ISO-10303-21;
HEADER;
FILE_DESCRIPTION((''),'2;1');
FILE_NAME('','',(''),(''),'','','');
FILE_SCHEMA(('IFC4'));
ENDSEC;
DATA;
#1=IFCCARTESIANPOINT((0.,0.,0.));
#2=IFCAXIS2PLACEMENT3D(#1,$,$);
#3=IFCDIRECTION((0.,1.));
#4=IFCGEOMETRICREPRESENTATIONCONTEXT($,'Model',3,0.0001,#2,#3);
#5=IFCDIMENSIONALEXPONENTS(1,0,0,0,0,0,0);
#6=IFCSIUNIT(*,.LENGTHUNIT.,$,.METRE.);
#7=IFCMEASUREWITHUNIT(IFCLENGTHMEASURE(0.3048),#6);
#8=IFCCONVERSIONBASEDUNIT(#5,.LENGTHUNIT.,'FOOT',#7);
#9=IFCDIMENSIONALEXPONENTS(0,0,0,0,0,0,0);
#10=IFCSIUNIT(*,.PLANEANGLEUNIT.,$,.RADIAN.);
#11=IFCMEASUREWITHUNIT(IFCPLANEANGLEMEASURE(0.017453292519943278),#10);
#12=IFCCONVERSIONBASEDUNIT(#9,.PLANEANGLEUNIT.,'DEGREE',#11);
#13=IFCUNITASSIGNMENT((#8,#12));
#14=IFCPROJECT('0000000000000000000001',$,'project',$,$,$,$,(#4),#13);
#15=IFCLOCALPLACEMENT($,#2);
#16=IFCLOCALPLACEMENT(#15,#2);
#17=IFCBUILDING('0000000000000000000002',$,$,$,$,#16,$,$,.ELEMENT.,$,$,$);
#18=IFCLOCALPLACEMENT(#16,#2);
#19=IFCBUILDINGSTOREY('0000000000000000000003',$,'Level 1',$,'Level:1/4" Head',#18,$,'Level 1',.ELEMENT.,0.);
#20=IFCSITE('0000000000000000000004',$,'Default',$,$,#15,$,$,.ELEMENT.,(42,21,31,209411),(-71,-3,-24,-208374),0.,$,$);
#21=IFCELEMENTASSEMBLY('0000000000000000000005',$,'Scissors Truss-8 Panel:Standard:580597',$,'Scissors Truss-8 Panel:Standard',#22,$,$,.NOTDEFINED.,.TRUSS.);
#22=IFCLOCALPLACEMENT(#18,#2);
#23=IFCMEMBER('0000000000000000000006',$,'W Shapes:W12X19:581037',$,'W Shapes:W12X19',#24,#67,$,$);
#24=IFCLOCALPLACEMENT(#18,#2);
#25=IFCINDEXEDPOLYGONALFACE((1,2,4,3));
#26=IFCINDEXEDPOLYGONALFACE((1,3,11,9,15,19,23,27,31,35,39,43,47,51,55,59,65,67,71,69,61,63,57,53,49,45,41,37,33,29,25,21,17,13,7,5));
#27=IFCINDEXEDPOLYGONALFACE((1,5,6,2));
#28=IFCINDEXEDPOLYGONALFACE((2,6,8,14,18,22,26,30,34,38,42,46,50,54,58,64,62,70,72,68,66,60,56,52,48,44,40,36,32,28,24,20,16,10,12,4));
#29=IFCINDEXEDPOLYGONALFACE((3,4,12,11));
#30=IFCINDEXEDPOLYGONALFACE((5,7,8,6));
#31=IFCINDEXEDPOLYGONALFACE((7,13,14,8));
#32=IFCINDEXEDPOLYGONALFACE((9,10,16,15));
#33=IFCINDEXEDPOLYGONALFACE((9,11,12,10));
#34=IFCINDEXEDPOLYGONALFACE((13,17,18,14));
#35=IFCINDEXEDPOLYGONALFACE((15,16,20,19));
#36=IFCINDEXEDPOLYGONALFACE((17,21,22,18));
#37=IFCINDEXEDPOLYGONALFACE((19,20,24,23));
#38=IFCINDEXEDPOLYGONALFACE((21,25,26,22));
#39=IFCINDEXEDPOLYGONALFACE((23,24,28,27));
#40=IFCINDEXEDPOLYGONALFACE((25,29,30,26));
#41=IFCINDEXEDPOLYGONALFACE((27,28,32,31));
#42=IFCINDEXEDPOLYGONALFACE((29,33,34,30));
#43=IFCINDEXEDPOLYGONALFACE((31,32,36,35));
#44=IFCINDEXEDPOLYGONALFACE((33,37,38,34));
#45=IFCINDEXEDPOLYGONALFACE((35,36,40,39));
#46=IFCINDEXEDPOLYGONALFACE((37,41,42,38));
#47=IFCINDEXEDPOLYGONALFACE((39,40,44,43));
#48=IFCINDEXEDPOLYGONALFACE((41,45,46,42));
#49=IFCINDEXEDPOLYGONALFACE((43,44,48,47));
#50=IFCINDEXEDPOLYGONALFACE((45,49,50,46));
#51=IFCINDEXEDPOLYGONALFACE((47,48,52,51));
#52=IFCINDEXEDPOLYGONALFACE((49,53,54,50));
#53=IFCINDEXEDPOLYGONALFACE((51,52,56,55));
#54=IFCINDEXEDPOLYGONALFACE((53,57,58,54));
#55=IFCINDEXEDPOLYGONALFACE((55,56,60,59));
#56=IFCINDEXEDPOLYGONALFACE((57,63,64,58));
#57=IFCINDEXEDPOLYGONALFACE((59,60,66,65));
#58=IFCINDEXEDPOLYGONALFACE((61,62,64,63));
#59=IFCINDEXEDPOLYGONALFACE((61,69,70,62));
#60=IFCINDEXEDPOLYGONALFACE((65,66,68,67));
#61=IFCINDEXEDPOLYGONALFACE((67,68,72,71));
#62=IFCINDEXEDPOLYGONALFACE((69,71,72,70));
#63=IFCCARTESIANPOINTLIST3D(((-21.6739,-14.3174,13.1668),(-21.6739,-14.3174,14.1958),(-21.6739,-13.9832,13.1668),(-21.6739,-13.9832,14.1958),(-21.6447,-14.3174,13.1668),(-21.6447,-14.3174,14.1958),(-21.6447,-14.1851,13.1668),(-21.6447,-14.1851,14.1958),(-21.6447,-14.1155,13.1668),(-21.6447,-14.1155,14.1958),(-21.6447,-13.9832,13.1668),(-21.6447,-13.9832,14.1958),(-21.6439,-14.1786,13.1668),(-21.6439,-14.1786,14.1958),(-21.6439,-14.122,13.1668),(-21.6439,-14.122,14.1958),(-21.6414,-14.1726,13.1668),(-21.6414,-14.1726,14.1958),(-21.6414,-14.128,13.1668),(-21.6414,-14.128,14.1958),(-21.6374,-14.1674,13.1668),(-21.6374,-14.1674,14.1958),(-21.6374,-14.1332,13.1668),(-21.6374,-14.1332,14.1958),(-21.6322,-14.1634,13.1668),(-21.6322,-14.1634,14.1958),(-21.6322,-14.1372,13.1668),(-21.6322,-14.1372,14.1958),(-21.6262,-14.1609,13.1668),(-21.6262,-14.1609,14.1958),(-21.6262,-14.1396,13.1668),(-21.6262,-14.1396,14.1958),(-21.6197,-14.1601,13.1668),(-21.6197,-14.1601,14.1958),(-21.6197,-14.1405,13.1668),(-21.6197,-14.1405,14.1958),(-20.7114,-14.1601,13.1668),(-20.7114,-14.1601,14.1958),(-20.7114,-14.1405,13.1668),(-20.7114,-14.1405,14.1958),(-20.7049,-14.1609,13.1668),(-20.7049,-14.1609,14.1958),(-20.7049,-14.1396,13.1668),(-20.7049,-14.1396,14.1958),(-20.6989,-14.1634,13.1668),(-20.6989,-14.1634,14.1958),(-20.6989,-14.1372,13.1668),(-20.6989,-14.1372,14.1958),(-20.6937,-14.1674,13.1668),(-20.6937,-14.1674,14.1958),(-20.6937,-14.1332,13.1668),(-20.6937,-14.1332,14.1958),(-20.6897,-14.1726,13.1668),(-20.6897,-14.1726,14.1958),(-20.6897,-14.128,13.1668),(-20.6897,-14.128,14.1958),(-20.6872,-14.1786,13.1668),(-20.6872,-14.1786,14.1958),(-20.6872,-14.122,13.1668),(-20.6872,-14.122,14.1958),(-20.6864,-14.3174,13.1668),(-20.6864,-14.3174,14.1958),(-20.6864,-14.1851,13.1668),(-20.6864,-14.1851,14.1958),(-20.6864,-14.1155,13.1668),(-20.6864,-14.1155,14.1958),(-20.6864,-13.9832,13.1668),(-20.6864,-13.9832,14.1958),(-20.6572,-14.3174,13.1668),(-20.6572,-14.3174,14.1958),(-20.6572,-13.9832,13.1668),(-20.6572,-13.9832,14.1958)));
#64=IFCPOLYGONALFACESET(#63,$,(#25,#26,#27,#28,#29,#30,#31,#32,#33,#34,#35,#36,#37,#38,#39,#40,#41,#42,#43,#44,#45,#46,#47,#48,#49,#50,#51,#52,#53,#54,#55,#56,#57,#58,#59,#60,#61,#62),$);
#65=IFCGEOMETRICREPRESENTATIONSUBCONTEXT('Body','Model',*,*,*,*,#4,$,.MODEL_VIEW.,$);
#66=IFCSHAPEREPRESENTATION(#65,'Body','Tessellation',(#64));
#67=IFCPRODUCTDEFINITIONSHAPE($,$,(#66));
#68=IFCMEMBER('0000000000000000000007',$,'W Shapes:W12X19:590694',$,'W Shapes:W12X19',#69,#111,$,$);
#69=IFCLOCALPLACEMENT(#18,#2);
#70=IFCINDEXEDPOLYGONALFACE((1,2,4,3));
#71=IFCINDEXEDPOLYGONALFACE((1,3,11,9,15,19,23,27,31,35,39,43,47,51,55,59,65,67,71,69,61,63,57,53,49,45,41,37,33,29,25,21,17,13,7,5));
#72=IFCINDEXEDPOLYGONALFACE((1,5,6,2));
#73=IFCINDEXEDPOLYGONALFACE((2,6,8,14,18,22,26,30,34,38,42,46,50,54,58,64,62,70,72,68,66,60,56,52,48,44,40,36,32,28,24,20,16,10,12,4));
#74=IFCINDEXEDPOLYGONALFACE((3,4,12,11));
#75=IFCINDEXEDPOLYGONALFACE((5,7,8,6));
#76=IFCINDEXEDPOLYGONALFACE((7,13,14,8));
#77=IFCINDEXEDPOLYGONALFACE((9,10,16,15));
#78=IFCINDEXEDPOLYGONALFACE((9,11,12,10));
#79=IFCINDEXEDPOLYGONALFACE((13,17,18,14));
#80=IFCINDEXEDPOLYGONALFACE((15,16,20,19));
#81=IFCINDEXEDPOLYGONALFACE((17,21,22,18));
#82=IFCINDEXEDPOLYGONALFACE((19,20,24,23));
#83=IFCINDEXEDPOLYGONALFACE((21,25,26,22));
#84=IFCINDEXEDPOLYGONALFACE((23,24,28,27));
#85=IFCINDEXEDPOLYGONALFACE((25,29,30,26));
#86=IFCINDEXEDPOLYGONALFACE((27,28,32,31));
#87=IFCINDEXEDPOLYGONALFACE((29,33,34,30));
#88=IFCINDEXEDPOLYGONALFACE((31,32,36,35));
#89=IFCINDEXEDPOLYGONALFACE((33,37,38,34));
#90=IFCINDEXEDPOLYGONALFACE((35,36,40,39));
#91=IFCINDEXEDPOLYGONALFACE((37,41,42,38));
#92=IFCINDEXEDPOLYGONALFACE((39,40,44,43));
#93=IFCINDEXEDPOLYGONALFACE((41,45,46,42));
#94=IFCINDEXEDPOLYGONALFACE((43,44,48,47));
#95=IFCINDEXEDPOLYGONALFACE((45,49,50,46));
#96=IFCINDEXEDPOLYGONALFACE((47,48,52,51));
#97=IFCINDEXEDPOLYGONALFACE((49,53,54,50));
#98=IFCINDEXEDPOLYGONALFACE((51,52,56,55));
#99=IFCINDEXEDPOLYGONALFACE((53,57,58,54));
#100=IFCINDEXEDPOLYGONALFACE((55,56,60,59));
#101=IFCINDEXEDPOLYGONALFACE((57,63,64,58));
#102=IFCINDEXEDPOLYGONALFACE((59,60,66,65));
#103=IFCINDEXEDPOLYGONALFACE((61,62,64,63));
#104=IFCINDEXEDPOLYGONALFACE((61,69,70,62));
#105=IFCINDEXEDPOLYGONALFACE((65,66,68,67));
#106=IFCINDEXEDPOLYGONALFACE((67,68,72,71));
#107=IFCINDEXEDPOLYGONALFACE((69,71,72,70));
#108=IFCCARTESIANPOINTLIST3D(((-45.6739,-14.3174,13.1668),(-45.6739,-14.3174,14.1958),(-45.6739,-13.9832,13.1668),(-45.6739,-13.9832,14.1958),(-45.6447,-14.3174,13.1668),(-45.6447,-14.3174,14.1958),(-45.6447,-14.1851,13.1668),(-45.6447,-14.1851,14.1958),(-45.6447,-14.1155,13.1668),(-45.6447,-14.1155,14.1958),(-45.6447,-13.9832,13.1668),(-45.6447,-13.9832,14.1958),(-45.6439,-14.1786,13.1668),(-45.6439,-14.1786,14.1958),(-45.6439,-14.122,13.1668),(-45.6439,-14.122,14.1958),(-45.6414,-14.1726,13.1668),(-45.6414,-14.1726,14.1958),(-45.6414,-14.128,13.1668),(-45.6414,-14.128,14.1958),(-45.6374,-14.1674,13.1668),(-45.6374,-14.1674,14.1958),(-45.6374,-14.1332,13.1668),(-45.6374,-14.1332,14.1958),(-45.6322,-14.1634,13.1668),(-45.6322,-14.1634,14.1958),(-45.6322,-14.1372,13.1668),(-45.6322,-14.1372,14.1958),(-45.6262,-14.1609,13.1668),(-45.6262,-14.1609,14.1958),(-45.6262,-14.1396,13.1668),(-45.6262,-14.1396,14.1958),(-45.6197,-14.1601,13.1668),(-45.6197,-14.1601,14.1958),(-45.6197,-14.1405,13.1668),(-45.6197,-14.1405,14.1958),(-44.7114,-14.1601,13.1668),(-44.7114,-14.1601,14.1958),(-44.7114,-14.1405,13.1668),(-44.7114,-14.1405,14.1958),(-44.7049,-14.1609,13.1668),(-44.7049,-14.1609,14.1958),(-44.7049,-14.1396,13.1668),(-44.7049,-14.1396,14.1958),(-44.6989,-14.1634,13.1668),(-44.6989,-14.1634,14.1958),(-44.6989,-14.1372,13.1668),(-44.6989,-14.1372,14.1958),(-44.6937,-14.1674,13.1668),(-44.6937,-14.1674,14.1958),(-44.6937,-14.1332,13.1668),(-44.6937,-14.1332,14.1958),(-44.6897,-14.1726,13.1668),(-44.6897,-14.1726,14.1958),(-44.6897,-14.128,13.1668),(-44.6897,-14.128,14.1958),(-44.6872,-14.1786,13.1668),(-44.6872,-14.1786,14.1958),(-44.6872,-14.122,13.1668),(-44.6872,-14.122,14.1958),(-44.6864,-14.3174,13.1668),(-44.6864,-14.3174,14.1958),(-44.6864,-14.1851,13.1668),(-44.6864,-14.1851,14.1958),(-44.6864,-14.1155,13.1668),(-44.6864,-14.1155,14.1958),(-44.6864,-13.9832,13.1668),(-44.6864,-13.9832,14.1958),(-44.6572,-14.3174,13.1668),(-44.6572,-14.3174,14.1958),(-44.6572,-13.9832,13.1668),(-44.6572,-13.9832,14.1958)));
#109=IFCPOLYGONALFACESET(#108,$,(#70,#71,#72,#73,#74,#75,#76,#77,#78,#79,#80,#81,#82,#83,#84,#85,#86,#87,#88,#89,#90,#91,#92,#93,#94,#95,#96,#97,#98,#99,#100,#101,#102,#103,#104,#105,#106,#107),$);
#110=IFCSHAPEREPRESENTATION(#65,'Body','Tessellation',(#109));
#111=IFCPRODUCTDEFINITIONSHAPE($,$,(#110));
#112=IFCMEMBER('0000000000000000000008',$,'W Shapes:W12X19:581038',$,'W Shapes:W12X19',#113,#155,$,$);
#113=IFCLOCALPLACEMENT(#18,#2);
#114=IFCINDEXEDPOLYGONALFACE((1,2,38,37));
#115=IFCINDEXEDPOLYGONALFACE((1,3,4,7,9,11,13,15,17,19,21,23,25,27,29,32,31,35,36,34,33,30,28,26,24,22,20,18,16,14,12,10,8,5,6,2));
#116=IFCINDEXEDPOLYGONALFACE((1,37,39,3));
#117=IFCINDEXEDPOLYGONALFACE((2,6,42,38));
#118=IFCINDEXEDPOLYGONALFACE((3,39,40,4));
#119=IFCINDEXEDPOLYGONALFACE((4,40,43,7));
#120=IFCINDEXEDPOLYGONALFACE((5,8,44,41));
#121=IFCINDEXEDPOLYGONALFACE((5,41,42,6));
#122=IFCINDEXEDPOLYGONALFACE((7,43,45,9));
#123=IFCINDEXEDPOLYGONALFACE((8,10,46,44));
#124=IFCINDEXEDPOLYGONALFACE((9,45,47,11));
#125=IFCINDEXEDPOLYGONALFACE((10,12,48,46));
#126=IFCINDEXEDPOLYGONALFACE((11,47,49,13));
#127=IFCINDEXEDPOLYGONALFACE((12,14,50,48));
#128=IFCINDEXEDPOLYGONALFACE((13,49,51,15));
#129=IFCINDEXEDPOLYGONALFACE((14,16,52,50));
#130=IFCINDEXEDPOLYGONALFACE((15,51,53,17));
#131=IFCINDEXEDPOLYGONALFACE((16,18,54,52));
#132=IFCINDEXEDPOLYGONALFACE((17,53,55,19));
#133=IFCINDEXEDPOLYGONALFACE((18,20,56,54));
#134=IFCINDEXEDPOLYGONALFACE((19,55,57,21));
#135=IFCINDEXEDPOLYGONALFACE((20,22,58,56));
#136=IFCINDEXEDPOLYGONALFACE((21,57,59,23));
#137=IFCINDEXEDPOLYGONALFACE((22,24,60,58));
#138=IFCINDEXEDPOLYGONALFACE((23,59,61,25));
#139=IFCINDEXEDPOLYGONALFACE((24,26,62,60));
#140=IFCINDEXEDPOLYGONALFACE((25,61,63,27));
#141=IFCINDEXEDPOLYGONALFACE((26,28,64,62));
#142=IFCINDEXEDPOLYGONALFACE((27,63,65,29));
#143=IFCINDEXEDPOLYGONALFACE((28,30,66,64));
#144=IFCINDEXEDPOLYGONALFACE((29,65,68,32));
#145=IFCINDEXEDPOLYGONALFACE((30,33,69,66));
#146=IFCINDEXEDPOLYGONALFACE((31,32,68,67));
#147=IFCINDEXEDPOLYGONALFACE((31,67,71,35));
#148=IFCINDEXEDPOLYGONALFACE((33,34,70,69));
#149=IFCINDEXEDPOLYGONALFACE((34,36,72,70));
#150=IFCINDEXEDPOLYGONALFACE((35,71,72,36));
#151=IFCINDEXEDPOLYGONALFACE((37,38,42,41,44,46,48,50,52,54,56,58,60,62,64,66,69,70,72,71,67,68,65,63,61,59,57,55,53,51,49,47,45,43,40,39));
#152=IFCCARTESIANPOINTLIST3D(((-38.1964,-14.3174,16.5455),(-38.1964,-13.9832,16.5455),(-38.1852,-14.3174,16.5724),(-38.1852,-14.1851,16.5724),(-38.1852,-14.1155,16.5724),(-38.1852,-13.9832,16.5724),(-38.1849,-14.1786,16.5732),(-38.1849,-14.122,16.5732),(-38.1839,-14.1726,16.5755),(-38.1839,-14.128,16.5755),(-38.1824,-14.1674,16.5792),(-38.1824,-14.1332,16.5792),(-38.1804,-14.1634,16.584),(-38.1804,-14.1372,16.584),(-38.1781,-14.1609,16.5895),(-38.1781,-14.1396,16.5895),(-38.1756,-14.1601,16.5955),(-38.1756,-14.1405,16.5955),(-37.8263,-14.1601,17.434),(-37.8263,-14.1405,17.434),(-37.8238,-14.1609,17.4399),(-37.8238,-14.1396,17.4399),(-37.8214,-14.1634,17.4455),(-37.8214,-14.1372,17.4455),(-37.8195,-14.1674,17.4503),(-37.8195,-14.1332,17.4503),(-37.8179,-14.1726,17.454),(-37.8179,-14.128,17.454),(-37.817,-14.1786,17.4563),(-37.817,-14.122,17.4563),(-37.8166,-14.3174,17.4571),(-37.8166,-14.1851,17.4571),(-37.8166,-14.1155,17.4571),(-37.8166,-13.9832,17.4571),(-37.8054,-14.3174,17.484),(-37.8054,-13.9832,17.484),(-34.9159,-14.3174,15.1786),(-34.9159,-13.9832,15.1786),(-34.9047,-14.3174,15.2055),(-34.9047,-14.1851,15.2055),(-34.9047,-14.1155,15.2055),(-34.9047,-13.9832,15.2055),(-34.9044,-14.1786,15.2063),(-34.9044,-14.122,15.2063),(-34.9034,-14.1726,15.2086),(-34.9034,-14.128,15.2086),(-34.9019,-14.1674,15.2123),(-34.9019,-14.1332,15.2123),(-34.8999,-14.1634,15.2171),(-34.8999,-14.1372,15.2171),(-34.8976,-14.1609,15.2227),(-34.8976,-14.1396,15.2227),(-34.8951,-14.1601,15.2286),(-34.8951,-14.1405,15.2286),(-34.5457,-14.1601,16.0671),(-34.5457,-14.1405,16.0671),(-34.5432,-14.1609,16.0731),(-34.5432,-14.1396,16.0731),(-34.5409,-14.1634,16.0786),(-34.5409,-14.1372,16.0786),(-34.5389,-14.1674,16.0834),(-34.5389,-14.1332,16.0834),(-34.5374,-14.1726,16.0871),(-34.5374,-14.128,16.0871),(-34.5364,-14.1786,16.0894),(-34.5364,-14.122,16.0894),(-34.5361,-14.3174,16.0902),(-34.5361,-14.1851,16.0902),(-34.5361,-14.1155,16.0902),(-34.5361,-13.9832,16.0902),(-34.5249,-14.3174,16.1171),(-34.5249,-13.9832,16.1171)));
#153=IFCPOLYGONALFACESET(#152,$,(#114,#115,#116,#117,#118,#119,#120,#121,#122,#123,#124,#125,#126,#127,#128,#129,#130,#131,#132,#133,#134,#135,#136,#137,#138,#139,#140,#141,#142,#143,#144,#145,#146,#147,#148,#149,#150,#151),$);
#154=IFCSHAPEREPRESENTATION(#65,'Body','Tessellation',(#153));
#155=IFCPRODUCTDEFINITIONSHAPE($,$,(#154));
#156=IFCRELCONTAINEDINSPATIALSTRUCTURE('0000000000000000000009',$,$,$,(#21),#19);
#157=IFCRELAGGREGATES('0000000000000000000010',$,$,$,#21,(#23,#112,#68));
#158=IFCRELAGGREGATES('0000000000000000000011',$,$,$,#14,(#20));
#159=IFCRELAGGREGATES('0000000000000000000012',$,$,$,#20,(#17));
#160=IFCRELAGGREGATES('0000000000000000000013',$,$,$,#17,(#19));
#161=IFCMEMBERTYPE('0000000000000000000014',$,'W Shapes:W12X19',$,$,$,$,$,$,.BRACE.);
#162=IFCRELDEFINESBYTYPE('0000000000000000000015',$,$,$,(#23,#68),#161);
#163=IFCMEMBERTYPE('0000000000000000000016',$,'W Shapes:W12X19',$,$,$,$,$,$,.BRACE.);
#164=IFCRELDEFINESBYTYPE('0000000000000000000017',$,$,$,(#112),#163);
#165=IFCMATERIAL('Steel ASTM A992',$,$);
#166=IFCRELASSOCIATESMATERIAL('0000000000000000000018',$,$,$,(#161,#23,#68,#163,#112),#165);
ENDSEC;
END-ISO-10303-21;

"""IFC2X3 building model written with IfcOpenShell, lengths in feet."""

from ifc_helpers import new_model, entity, si_unit, converted_unit, direction, frame, frame_2d, origin, place, context, subcontext, project, spatial, polyline, circle_curve, parameter, trimmed, segment, composite_curve, outline, extrude, source, transform, mapped, material, type_object, type_shapes, element, aggregate, save


model = new_model("IFC2X3")

# Units and contexts
model_context = context("Model", 3, precision=0.0001, world=origin(), true_north=direction((0.0, 1.0)))
body_context = subcontext(model_context, "Body", "Model", "MODEL_VIEW")
ifc_project = project(units=[converted_unit("LENGTHUNIT", "FOOT", entity("IfcLengthMeasure", 0.3048), si_unit("LENGTHUNIT", "METRE"), dimensions=[1, 0, 0, 0, 0, 0, 0]), converted_unit("PLANEANGLEUNIT", "DEGREE", entity("IfcPlaneAngleMeasure", 0.017453292519943278), si_unit("PLANEANGLEUNIT", "RADIAN"), dimensions=[0, 0, 0, 0, 0, 0, 0])], contexts=[model_context])

# Site, building, storey
site_placement = place(None, origin())
site = spatial("IfcSite", under=ifc_project, at=site_placement, Name="Default", CompositionType="ELEMENT", RefLatitude=(42, 21, 31, 209411), RefLongitude=(-71, -3, -24, -208374), RefElevation=0.0)
building_placement = place(site_placement, origin())
building = spatial("IfcBuilding", under=site, at=building_placement, CompositionType="ELEMENT")
storey_placement = place(building_placement, origin())
storey = spatial("IfcBuildingStorey", under=building, at=storey_placement, Name="Level 1", ObjectType="Level:1/4\" Head", LongName="Level 1", CompositionType="ELEMENT", Elevation=0.0)

# Element assembly, members
assembly_placement = place(storey_placement, origin())
assembly = element("IfcElementAssembly", 1, at=assembly_placement, inside=storey, Name="Scissors Truss-8 Panel:Standard:580597", ObjectType="Scissors Truss-8 Panel:Standard", AssemblyPlace="NOTDEFINED", PredefinedType="TRUSS")
ifc_material = material(Name="Steel ASTM A992")
member_type_1 = type_object("IfcMemberType", Name="W Shapes:W12X19", PredefinedType="BRACE", material=ifc_material)
shared_shape_1 = source(origin(), body_context, "Body", "SweptSolid", [
    extrude(outline(composite_curve([segment(polyline([(-0.1671, -0.4792), (-0.1671, -0.5083)]), True, "CONTINUOUS"), segment(polyline([(-0.1671, -0.5083), (0.1671, -0.5083)]), True, "CONTINUOUS"), segment(polyline([(0.1671, -0.5083), (0.1671, -0.4792)]), True, "CONTINUOUS"), segment(polyline([(0.1671, -0.4792), (0.0348, -0.4792)]), True, "CONTINUOUS"), segment(trimmed(circle_curve(frame_2d((0.0348, -0.4542), x_axis=(0.0, -1.0)), 0.025), [parameter(270.0)], [parameter(360.0)], True, "PARAMETER"), False, "CONTINUOUS"), segment(polyline([(0.0098, -0.4542), (0.0098, 0.4542)]), True, "CONTINUOUS"), segment(trimmed(circle_curve(frame_2d((0.0348, 0.4542), x_axis=(-1.0, 0.0)), 0.025), [parameter(270.0)], [parameter(360.0)], True, "PARAMETER"), False, "CONTINUOUS"), segment(polyline([(0.0348, 0.4792), (0.1671, 0.4792)]), True, "CONTINUOUS"), segment(polyline([(0.1671, 0.4792), (0.1671, 0.5083)]), True, "CONTINUOUS"), segment(polyline([(0.1671, 0.5083), (-0.1671, 0.5083)]), True, "CONTINUOUS"), segment(polyline([(-0.1671, 0.5083), (-0.1671, 0.4792)]), True, "CONTINUOUS"), segment(polyline([(-0.1671, 0.4792), (-0.0348, 0.4792)]), True, "CONTINUOUS"), segment(trimmed(circle_curve(frame_2d((-0.0348, 0.4542), x_axis=(0.0, 1.0)), 0.025), [parameter(270.0)], [parameter(0.0)], True, "PARAMETER"), False, "CONTINUOUS"), segment(polyline([(-0.0098, 0.4542), (-0.0098, -0.4542)]), True, "CONTINUOUS"), segment(trimmed(circle_curve(frame_2d((-0.0348, -0.4542), x_axis=(1.0, 0.0)), 0.025), [parameter(270.0)], [parameter(0.0)], True, "PARAMETER"), False, "CONTINUOUS"), segment(polyline([(-0.0348, -0.4792), (-0.1671, -0.4792)]), True, "CONTINUOUS")], self_intersect=False)), frame((-0.5832, 0.0, 0.0), z_axis=(-1.0, 0.0, 0.0), x_axis=(0.0, -1.0, 0.0)), (0.0, 0.0, -1.0), 1.029),
])
type_shapes(member_type_1, [shared_shape_1])
member_1_placement = place(assembly_placement, frame((-21.1655, -14.1503, 13.75), z_axis=(1.0, 0.0, 0.0), x_axis=(0.0, 0.0, 1.0)))
member_1 = element("IfcMember", 2, at=member_1_placement, type_object=member_type_1, material=ifc_material, Name="W Shapes:W12X19:581037", ObjectType="W Shapes:W12X19", context=body_context, shape_type="MappedRepresentation", body=[
    mapped(shared_shape_1, transform((0.0, 0.0, 0.0), scale=1.0)),
])
member_2_placement = place(assembly_placement, frame((-45.1655, -14.1503, 13.75), z_axis=(1.0, 0.0, 0.0), x_axis=(0.0, 0.0, 1.0)))
member_2 = element("IfcMember", 3, at=member_2_placement, type_object=member_type_1, material=ifc_material, Name="W Shapes:W12X19:590694", ObjectType="W Shapes:W12X19", context=body_context, shape_type="MappedRepresentation", body=[
    mapped(shared_shape_1, transform((0.0, 0.0, 0.0), scale=1.0)),
])
member_type_2 = type_object("IfcMemberType", Name="W Shapes:W12X19", PredefinedType="BRACE", material=ifc_material)
shared_shape_2 = source(origin(), body_context, "Body", "SweptSolid", [
    extrude(outline(composite_curve([segment(polyline([(-0.1671, -0.4792), (-0.1671, -0.5083)]), True, "CONTINUOUS"), segment(polyline([(-0.1671, -0.5083), (0.1671, -0.5083)]), True, "CONTINUOUS"), segment(polyline([(0.1671, -0.5083), (0.1671, -0.4792)]), True, "CONTINUOUS"), segment(polyline([(0.1671, -0.4792), (0.0348, -0.4792)]), True, "CONTINUOUS"), segment(trimmed(circle_curve(frame_2d((0.0348, -0.4542), x_axis=(1.0, 0.0)), 0.025), [parameter(180.0)], [parameter(270.0)], True, "PARAMETER"), False, "CONTINUOUS"), segment(polyline([(0.0098, -0.4542), (0.0098, 0.4542)]), True, "CONTINUOUS"), segment(trimmed(circle_curve(frame_2d((0.0348, 0.4542), x_axis=(1.0, 0.0)), 0.025), [parameter(90.0)], [parameter(180.0)], True, "PARAMETER"), False, "CONTINUOUS"), segment(polyline([(0.0348, 0.4792), (0.1671, 0.4792)]), True, "CONTINUOUS"), segment(polyline([(0.1671, 0.4792), (0.1671, 0.5083)]), True, "CONTINUOUS"), segment(polyline([(0.1671, 0.5083), (-0.1671, 0.5083)]), True, "CONTINUOUS"), segment(polyline([(-0.1671, 0.5083), (-0.1671, 0.4792)]), True, "CONTINUOUS"), segment(polyline([(-0.1671, 0.4792), (-0.0348, 0.4792)]), True, "CONTINUOUS"), segment(trimmed(circle_curve(frame_2d((-0.0348, 0.4542), x_axis=(1.0, 0.0)), 0.025), [parameter(360.0)], [parameter(90.0)], True, "PARAMETER"), False, "CONTINUOUS"), segment(polyline([(-0.0098, 0.4542), (-0.0098, -0.4542)]), True, "CONTINUOUS"), segment(trimmed(circle_curve(frame_2d((-0.0348, -0.4542), x_axis=(1.0, 0.0)), 0.025), [parameter(270.0)], [parameter(360.0)], True, "PARAMETER"), False, "CONTINUOUS"), segment(polyline([(-0.0348, -0.4792), (-0.1671, -0.4792)]), True, "CONTINUOUS")], self_intersect=False)), frame((-1.9883, 0.0, 0.0), z_axis=(-1.0, 0.0, 0.0), x_axis=(0.0, -1.0, 0.0)), (0.0, 0.0, -1.0), 3.5539),
])
type_shapes(member_type_2, [shared_shape_2])
member_3_placement = place(assembly_placement, frame((-36.1655, -14.1503, 16.25), z_axis=(-0.384615, 0.0, -0.923077), x_axis=(0.923077, 0.0, -0.384615)))
member_3 = element("IfcMember", 4, at=member_3_placement, type_object=member_type_2, material=ifc_material, Name="W Shapes:W12X19:581038", ObjectType="W Shapes:W12X19", context=body_context, shape_type="MappedRepresentation", body=[
    mapped(shared_shape_2, transform((0.0, 0.0, 0.0), scale=1.0)),
])
aggregate(assembly, [member_1, member_3, member_2])

save(model, "model.ifc")
